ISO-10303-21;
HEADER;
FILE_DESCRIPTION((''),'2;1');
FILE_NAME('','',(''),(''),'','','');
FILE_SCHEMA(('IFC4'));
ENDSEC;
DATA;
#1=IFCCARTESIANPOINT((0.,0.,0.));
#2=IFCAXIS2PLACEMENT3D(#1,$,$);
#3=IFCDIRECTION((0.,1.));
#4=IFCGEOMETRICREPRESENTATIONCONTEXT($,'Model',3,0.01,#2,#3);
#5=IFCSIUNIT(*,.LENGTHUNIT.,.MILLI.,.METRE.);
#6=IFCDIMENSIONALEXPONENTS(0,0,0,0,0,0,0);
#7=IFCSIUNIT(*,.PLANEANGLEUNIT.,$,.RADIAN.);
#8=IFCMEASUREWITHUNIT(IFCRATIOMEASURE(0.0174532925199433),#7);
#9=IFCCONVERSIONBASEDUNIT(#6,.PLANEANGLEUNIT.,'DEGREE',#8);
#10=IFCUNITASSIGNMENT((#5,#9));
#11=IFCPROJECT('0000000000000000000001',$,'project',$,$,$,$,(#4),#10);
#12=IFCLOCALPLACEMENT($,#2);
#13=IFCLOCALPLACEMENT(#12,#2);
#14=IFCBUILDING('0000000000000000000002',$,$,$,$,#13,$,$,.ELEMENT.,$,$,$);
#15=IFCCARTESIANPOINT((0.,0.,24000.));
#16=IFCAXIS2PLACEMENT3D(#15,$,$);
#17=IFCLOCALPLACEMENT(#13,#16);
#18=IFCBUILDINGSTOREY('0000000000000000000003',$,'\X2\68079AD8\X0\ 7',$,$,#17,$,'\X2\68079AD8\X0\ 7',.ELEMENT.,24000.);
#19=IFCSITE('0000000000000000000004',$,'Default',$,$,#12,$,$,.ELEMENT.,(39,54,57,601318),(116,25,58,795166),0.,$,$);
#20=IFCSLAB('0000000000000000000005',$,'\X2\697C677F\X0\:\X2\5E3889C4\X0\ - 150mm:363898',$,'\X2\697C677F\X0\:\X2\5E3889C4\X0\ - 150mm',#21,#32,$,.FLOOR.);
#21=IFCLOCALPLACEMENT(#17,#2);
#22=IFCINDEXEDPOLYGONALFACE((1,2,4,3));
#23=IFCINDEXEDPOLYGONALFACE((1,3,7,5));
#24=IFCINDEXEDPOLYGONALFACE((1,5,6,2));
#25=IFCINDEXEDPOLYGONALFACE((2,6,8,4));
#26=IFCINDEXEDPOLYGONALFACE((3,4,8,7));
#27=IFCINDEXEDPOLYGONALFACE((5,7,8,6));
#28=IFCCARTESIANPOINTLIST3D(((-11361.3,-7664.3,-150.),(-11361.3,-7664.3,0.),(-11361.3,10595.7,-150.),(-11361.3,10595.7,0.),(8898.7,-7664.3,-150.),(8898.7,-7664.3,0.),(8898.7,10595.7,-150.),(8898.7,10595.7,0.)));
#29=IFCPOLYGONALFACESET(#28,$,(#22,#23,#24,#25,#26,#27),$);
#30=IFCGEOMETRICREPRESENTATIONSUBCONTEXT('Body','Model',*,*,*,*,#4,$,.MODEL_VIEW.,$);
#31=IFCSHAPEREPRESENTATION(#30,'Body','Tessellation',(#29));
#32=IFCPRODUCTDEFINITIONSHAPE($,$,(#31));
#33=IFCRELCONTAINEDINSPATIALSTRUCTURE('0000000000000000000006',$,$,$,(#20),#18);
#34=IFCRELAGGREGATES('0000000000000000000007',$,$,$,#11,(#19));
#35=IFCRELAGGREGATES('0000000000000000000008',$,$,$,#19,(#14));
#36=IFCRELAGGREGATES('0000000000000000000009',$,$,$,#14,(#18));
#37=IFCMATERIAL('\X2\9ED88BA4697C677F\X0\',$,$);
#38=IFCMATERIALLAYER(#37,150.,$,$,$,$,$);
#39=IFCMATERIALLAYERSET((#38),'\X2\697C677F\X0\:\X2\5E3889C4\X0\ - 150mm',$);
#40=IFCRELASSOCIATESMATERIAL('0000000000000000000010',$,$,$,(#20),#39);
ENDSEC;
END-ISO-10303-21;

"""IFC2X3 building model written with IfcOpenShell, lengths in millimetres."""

from ifc_helpers import new_model, entity, si_unit, converted_unit, direction, frame, frame_2d, origin, place, context, subcontext, project, spatial, rectangle, extrude, material, layer, layer_set, layer_usage, element, save


model = new_model("IFC2X3")

# Units and contexts
model_context = context("Model", 3, precision=0.01, world=origin(), true_north=direction((0.0, 1.0)))
body_context = subcontext(model_context, "Body", "Model", "MODEL_VIEW")
ifc_project = project(units=[si_unit("LENGTHUNIT", "METRE", prefix="MILLI"), converted_unit("PLANEANGLEUNIT", "DEGREE", entity("IfcRatioMeasure", 0.0174532925199433), si_unit("PLANEANGLEUNIT", "RADIAN"), dimensions=[0, 0, 0, 0, 0, 0, 0])], contexts=[model_context])

# Site, building, storey
site_placement = place(None, origin())
site = spatial("IfcSite", under=ifc_project, at=site_placement, Name="Default", CompositionType="ELEMENT", RefLatitude=(39, 54, 57, 601318), RefLongitude=(116, 25, 58, 795166), RefElevation=0.0)
building_placement = place(site_placement, origin())
building = spatial("IfcBuilding", under=site, at=building_placement, CompositionType="ELEMENT")
storey_placement = place(building_placement, frame((0.0, 0.0, 24000.0)))
storey = spatial("IfcBuildingStorey", under=building, at=storey_placement, Name="标高 7", LongName="标高 7", CompositionType="ELEMENT", Elevation=24000.0)

# Slab
ifc_material_1 = material(Name="默认楼板")
ifc_layer = layer(ifc_material_1, 150.0)
ifc_layer_set = layer_set([ifc_layer], Name="楼板:常规 - 150mm")
ifc_layer_usage = layer_usage(ifc_layer_set, "AXIS3", "POSITIVE", 0.0)
slab_placement = place(storey_placement, origin())
element("IfcSlab", 1, at=slab_placement, inside=storey, material=ifc_layer_usage, Name="楼板:常规 - 150mm:363898", ObjectType="楼板:常规 - 150mm", PredefinedType="FLOOR", context=body_context, shape_type="SweptSolid", body=[
    extrude(rectangle(XDim=18260.0, YDim=20260.0, at=frame_2d((0.0, 0.0), x_axis=(1.0, 0.0))), frame((-1231.3, 1465.7, 0.0), z_axis=(0.0, 0.0, -1.0), x_axis=(0.0, 1.0, 0.0)), (0.0, 0.0, 1.0), 150.0),
])

save(model, "model.ifc")
